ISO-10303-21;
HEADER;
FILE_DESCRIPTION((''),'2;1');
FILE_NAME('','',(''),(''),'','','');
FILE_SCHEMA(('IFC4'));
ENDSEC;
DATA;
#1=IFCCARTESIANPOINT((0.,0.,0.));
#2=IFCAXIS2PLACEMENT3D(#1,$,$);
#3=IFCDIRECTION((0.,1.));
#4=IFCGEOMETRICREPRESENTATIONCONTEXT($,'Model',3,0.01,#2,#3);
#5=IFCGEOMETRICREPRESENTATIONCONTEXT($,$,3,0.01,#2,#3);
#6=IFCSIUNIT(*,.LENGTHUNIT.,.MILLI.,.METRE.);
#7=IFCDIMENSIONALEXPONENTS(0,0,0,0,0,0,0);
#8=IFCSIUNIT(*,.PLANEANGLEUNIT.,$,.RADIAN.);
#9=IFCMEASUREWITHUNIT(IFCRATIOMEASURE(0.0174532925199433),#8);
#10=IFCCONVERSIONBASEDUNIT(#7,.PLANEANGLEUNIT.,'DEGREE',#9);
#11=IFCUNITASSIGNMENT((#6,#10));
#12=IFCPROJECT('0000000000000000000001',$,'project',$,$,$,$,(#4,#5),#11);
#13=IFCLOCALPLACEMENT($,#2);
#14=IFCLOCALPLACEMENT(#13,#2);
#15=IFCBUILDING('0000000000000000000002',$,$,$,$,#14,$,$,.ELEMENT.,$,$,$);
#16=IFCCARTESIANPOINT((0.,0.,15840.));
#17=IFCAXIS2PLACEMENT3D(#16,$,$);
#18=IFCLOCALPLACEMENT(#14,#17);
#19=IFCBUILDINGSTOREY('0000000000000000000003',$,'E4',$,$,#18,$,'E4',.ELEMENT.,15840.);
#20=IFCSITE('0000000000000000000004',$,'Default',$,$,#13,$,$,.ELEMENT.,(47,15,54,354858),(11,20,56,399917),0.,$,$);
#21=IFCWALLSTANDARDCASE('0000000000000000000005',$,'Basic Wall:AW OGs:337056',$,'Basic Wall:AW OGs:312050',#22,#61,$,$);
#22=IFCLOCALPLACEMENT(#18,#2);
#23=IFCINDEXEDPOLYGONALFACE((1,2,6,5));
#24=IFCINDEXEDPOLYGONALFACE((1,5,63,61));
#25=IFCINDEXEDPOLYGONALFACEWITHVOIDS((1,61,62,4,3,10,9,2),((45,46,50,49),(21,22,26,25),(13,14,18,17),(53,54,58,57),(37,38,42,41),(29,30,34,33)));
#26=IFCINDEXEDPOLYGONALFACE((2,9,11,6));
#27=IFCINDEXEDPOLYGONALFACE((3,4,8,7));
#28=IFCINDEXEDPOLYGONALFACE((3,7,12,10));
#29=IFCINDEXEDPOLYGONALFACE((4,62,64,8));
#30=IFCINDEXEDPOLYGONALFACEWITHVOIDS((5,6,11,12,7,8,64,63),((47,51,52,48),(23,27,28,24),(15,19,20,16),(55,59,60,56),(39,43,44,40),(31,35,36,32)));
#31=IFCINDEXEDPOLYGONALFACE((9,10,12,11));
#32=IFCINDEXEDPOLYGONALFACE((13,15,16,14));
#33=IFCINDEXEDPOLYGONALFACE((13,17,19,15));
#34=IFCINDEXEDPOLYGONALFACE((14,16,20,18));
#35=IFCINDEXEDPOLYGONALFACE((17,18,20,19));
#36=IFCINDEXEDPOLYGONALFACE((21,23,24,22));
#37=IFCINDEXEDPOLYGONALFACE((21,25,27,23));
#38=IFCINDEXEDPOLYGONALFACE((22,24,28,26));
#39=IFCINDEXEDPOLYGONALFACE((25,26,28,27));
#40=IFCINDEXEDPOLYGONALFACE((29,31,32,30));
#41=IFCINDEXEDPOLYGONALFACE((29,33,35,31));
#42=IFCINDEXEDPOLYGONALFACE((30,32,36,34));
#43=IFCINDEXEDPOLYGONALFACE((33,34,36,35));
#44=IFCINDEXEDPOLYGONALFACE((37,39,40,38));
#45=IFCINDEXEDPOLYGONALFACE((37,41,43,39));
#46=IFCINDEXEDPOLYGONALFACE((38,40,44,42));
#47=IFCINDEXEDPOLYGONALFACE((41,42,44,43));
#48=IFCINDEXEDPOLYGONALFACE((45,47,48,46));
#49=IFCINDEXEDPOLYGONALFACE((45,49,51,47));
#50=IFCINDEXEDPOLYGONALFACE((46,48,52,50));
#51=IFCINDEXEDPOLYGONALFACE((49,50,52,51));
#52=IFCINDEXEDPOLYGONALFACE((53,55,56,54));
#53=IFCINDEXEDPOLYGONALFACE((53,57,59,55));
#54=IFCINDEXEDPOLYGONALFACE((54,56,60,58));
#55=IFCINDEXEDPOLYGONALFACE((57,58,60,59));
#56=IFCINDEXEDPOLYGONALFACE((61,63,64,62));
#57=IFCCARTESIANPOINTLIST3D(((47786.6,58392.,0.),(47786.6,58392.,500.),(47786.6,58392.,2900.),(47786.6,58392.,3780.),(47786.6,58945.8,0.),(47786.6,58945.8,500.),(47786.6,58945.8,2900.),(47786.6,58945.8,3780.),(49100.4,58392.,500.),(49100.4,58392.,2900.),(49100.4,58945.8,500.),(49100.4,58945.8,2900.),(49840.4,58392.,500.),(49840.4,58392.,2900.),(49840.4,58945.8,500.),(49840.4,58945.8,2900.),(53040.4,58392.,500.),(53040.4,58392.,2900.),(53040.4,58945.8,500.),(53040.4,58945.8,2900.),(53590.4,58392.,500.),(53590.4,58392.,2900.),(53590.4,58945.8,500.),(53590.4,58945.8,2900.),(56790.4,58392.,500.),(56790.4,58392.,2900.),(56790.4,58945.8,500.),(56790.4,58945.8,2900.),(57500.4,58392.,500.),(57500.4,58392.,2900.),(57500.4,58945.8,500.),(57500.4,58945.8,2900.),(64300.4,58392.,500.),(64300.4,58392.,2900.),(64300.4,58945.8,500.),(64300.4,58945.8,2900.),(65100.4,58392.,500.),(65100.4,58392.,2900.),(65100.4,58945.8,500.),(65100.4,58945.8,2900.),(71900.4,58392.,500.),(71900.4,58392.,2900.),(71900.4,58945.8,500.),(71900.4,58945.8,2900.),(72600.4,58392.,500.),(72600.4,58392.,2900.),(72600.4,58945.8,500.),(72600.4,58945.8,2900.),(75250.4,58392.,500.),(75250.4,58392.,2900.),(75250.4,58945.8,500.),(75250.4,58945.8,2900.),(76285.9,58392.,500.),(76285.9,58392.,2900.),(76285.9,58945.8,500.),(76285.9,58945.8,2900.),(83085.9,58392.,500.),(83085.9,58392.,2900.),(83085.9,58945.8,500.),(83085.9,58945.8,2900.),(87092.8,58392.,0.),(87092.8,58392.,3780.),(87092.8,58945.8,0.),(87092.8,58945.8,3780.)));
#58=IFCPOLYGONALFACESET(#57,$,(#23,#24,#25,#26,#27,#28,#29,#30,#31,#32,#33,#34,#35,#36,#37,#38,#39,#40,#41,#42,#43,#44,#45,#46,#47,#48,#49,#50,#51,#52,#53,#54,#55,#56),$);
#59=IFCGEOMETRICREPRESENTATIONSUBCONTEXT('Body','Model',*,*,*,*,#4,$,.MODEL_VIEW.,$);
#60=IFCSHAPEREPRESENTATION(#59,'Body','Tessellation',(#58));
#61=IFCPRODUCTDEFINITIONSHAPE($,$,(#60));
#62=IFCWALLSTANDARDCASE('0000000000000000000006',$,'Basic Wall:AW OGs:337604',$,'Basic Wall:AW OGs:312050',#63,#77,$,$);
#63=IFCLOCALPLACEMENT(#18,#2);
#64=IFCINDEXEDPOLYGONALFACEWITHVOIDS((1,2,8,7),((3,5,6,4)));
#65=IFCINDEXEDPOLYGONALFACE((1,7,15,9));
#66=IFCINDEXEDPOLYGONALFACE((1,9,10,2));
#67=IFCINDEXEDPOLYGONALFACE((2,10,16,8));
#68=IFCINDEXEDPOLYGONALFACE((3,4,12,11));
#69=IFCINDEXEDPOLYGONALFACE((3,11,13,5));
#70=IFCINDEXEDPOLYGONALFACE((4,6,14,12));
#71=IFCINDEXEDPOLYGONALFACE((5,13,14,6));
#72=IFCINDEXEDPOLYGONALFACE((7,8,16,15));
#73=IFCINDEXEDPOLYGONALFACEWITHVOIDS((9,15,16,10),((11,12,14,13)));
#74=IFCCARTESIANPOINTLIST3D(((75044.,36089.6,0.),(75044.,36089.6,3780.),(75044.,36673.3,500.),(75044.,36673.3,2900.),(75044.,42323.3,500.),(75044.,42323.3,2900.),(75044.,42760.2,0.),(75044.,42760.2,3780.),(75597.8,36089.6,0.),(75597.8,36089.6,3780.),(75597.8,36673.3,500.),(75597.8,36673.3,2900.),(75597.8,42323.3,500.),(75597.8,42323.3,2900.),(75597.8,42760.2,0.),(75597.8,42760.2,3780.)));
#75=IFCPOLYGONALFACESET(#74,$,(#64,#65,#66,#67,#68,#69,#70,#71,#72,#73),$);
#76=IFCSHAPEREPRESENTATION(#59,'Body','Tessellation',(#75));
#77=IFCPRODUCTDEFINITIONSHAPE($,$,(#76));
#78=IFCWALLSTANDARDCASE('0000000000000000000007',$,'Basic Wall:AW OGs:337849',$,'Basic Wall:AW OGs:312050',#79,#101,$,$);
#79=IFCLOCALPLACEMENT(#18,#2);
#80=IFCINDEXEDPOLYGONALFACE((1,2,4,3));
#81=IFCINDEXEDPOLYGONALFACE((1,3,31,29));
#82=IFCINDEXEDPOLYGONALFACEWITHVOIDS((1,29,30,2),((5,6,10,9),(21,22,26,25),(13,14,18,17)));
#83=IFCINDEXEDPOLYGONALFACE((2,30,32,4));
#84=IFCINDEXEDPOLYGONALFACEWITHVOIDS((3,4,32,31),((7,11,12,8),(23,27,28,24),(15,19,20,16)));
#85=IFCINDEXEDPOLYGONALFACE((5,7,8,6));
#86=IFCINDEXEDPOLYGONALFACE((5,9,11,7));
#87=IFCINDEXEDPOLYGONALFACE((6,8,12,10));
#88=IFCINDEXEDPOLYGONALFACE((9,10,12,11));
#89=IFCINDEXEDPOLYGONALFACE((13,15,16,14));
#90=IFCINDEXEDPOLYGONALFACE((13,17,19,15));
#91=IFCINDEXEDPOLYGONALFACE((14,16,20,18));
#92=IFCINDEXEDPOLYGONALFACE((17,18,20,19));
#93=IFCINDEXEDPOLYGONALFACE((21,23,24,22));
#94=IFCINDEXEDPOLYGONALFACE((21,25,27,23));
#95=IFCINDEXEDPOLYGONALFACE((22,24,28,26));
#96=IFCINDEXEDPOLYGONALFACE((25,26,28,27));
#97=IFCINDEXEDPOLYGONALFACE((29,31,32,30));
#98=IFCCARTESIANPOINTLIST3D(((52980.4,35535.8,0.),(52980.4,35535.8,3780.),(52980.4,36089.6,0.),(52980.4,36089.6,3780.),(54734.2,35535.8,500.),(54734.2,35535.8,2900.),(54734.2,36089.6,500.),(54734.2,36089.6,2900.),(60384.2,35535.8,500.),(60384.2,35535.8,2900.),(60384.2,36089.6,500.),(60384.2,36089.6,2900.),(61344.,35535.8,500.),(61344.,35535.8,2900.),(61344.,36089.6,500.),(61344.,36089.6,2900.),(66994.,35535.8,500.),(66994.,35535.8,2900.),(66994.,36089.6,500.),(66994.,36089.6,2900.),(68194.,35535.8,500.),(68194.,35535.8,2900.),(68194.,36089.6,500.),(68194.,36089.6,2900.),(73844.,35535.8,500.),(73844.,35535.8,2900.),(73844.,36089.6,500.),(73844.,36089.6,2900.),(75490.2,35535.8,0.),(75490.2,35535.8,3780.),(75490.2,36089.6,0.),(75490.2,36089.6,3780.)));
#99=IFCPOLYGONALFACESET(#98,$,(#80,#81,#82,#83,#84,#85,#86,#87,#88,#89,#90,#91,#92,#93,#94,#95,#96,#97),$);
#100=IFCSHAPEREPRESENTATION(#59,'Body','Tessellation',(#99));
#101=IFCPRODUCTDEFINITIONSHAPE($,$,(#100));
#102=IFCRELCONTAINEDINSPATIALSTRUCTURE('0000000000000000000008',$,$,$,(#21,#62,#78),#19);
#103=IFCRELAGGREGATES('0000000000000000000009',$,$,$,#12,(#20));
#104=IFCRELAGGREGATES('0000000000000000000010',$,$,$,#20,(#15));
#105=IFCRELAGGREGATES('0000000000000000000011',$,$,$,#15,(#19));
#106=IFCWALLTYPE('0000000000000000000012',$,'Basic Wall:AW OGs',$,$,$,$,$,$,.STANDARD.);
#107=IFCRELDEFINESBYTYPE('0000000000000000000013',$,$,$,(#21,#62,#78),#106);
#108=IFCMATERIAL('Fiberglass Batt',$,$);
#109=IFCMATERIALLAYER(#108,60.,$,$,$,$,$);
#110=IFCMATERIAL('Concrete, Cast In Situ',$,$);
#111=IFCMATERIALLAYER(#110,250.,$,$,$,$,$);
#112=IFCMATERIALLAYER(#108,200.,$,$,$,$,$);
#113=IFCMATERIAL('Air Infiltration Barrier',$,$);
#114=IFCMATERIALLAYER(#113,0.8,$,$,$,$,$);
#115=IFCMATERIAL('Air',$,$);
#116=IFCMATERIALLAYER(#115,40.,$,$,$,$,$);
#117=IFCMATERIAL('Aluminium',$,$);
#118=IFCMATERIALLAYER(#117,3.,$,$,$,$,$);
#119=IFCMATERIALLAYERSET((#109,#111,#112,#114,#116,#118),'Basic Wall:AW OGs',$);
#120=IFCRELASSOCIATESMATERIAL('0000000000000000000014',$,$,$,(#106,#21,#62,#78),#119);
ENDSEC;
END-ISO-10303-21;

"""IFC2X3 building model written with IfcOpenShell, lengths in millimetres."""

from ifc_helpers import new_model, entity, si_unit, converted_unit, direction, frame, frame_2d, origin, place, context, subcontext, project, spatial, rectangle, extrude, material, layer, layer_set, layer_usage, type_object, element, save


model = new_model("IFC2X3")

# Units and contexts
model_context = context("Model", 3, precision=0.01, world=origin(), true_north=direction((0.0, 1.0)))
context_of_model = context(None, 3, precision=0.01, world=origin(), true_north=direction((0.0, 1.0)))
body_context = subcontext(model_context, "Body", "Model", "MODEL_VIEW")
ifc_project = project(units=[si_unit("LENGTHUNIT", "METRE", prefix="MILLI"), converted_unit("PLANEANGLEUNIT", "DEGREE", entity("IfcRatioMeasure", 0.0174532925199433), si_unit("PLANEANGLEUNIT", "RADIAN"), dimensions=[0, 0, 0, 0, 0, 0, 0])], contexts=[model_context, context_of_model])

# Site, building, storey
site_placement = place(None, origin())
site = spatial("IfcSite", under=ifc_project, at=site_placement, Name="Default", CompositionType="ELEMENT", RefLatitude=(47, 15, 54, 354858), RefLongitude=(11, 20, 56, 399917), RefElevation=0.0)
building_placement = place(site_placement, origin())
building = spatial("IfcBuilding", under=site, at=building_placement, CompositionType="ELEMENT")
storey_placement = place(building_placement, frame((0.0, 0.0, 15840.0)))
storey = spatial("IfcBuildingStorey", under=building, at=storey_placement, Name="E4", LongName="E4", CompositionType="ELEMENT", Elevation=15840.0)

# Shared definitions
ifc_material_1 = material(Name="Concrete, Cast In Situ")

# Shared definitions
ifc_material_2 = material(Name="Fiberglass Batt")
ifc_layer_1 = layer(ifc_material_2, 60.0)
ifc_layer_2 = layer(ifc_material_1, 250.0)
ifc_layer_3 = layer(ifc_material_2, 200.0)
ifc_material_3 = material(Name="Air Infiltration Barrier")
ifc_layer_4 = layer(ifc_material_3, 0.8)
ifc_material_4 = material(Name="Air")
ifc_layer_5 = layer(ifc_material_4, 40.0)
ifc_material_5 = material(Name="Aluminium")
ifc_layer_6 = layer(ifc_material_5, 3.0)
ifc_layer_set_1 = layer_set([ifc_layer_1, ifc_layer_2, ifc_layer_3, ifc_layer_4, ifc_layer_5, ifc_layer_6], Name="Basic Wall:AW OGs")
wall_type_1 = type_object("IfcWallType", Name="Basic Wall:AW OGs", PredefinedType="STANDARD", material=ifc_layer_set_1)

# Wall, openings
ifc_layer_usage_1 = layer_usage(ifc_layer_set_1, "AXIS2", "NEGATIVE", 276.9)
wall_1_placement = place(storey_placement, frame((87092.8, 58668.9, 0.0), z_axis=(0.0, 0.0, 1.0), x_axis=(-1.0, 0.0, 0.0)))
wall_1 = element("IfcWallStandardCase", 1, at=wall_1_placement, inside=storey, type_object=wall_type_1, material=ifc_layer_usage_1, Name="Basic Wall:AW OGs:337056", ObjectType="Basic Wall:AW OGs:312050", context=body_context, shape_type="SweptSolid", body=[
    extrude(rectangle(XDim=39306.2, YDim=553.8, at=frame_2d((19653.1, 0.0), x_axis=(-1.0, 0.0))), origin(), (0.0, 0.0, 1.0), 3780.0),
])
opening_1_placement = place(wall_1_placement, frame((44792.4, 276.9, 500.0)))
element("IfcOpeningElement", 2, at=opening_1_placement, cuts=wall_1, ObjectType="Opening", context=body_context, shape_type="SweptSolid", body=[
    extrude(rectangle(XDim=2400.0, YDim=6800.0, at=frame_2d((1200.0, 3400.0), x_axis=(-1.0, 0.0))), frame((0.0, 0.0, 0.0), z_axis=(0.0, -1.0, 0.0), x_axis=(0.0, 0.0, 1.0)), (0.0, 0.0, 1.0), 553.8),
])
opening_2_placement = place(wall_1_placement, frame((37252.4, 276.9, 500.0)))
element("IfcOpeningElement", 3, at=opening_2_placement, cuts=wall_1, ObjectType="Opening", context=body_context, shape_type="SweptSolid", body=[
    extrude(rectangle(XDim=2400.0, YDim=3200.0, at=frame_2d((1200.0, 1600.0), x_axis=(-1.0, 0.0))), frame((0.0, 0.0, 0.0), z_axis=(0.0, -1.0, 0.0), x_axis=(0.0, 0.0, 1.0)), (0.0, 0.0, 1.0), 553.8),
])
opening_3_placement = place(wall_1_placement, frame((10806.8, 276.9, 500.0)))
element("IfcOpeningElement", 4, at=opening_3_placement, cuts=wall_1, ObjectType="Opening", context=body_context, shape_type="SweptSolid", body=[
    extrude(rectangle(XDim=2400.0, YDim=6800.0, at=frame_2d((1200.0, 3400.0), x_axis=(-1.0, 0.0))), frame((0.0, 0.0, 0.0), z_axis=(0.0, -1.0, 0.0), x_axis=(0.0, 0.0, 1.0)), (0.0, 0.0, 1.0), 553.8),
])
opening_4_placement = place(wall_1_placement, frame((33502.4, 276.9, 500.0)))
element("IfcOpeningElement", 5, at=opening_4_placement, cuts=wall_1, ObjectType="Opening", context=body_context, shape_type="SweptSolid", body=[
    extrude(rectangle(XDim=2400.0, YDim=3200.0, at=frame_2d((1200.0, 1600.0), x_axis=(-1.0, 0.0))), frame((0.0, 0.0, 0.0), z_axis=(0.0, -1.0, 0.0), x_axis=(0.0, 0.0, 1.0)), (0.0, 0.0, 1.0), 553.8),
])
opening_5_placement = place(wall_1_placement, frame((14492.4, 276.9, 500.0)))
element("IfcOpeningElement", 6, at=opening_5_placement, cuts=wall_1, ObjectType="Opening", context=body_context, shape_type="SweptSolid", body=[
    extrude(rectangle(XDim=2400.0, YDim=2650.0, at=frame_2d((1200.0, 1325.0), x_axis=(-1.0, 0.0))), frame((0.0, 0.0, 0.0), z_axis=(0.0, -1.0, 0.0), x_axis=(0.0, 0.0, 1.0)), (0.0, 0.0, 1.0), 553.8),
])
opening_6_placement = place(wall_1_placement, frame((21992.4, 276.9, 500.0)))
element("IfcOpeningElement", 7, at=opening_6_placement, cuts=wall_1, ObjectType="Opening", context=body_context, shape_type="SweptSolid", body=[
    extrude(rectangle(XDim=2400.0, YDim=6800.0, at=frame_2d((1200.0, 3400.0), x_axis=(-1.0, 0.0))), frame((0.0, 0.0, 0.0), z_axis=(0.0, -1.0, 0.0), x_axis=(0.0, 0.0, 1.0)), (0.0, 0.0, 1.0), 553.8),
])
opening_7_placement = place(wall_1_placement, frame((29592.4, 276.9, 500.0)))
element("IfcOpeningElement", 8, at=opening_7_placement, cuts=wall_1, ObjectType="Opening", context=body_context, shape_type="SweptSolid", body=[
    extrude(rectangle(XDim=2400.0, YDim=6800.0, at=frame_2d((1200.0, 3400.0), x_axis=(-1.0, 0.0))), frame((0.0, 0.0, 0.0), z_axis=(0.0, -1.0, 0.0), x_axis=(0.0, 0.0, 1.0)), (0.0, 0.0, 1.0), 553.8),
])

# Wall, opening
ifc_layer_usage_2 = layer_usage(ifc_layer_set_1, "AXIS2", "NEGATIVE", 276.9)
wall_2_placement = place(storey_placement, frame((75320.9, 42760.2, 0.0), z_axis=(0.0, 0.0, 1.0), x_axis=(0.0, -1.0, 0.0)))
wall_2 = element("IfcWallStandardCase", 9, at=wall_2_placement, inside=storey, type_object=wall_type_1, material=ifc_layer_usage_2, Name="Basic Wall:AW OGs:337604", ObjectType="Basic Wall:AW OGs:312050", context=body_context, shape_type="SweptSolid", body=[
    extrude(rectangle(XDim=6670.6, YDim=553.8, at=frame_2d((3335.3, 0.0), x_axis=(-1.0, 0.0))), origin(), (0.0, 0.0, 1.0), 3780.0),
])
opening_8_placement = place(wall_2_placement, frame((6086.9, 276.9, 500.0)))
element("IfcOpeningElement", 10, at=opening_8_placement, cuts=wall_2, ObjectType="Opening", context=body_context, shape_type="SweptSolid", body=[
    extrude(rectangle(XDim=2400.0, YDim=5650.0, at=frame_2d((1200.0, 2825.0), x_axis=(-1.0, 0.0))), frame((0.0, 0.0, 0.0), z_axis=(0.0, -1.0, 0.0), x_axis=(0.0, 0.0, 1.0)), (0.0, 0.0, 1.0), 553.8),
])

# Wall, openings
ifc_layer_usage_3 = layer_usage(ifc_layer_set_1, "AXIS2", "NEGATIVE", 276.9)
wall_3_placement = place(storey_placement, frame((75597.8, 35812.7, 0.0), z_axis=(0.0, 0.0, 1.0), x_axis=(-1.0, 0.0, 0.0)))
wall_3 = element("IfcWallStandardCase", 11, at=wall_3_placement, inside=storey, type_object=wall_type_1, material=ifc_layer_usage_3, Name="Basic Wall:AW OGs:337849", ObjectType="Basic Wall:AW OGs:312050", context=body_context, shape_type="SweptSolid", body=[
    extrude(rectangle(XDim=22509.8, YDim=553.8, at=frame_2d((11362.5, 0.0), x_axis=(-1.0, 0.0))), origin(), (0.0, 0.0, 1.0), 3780.0),
])
opening_9_placement = place(wall_3_placement, frame((20863.6, 276.9, 500.0)))
element("IfcOpeningElement", 12, at=opening_9_placement, cuts=wall_3, ObjectType="Opening", context=body_context, shape_type="SweptSolid", body=[
    extrude(rectangle(XDim=2400.0, YDim=5650.0, at=frame_2d((1200.0, 2825.0), x_axis=(-1.0, 0.0))), frame((0.0, 0.0, 0.0), z_axis=(0.0, -1.0, 0.0), x_axis=(0.0, 0.0, 1.0)), (0.0, 0.0, 1.0), 553.8),
])
opening_10_placement = place(wall_3_placement, frame((14253.8, 276.9, 500.0)))
element("IfcOpeningElement", 13, at=opening_10_placement, cuts=wall_3, ObjectType="Opening", context=body_context, shape_type="SweptSolid", body=[
    extrude(rectangle(XDim=2400.0, YDim=5650.0, at=frame_2d((1200.0, 2825.0), x_axis=(-1.0, 0.0))), frame((0.0, 0.0, 0.0), z_axis=(0.0, -1.0, 0.0), x_axis=(0.0, 0.0, 1.0)), (0.0, 0.0, 1.0), 553.8),
])
opening_11_placement = place(wall_3_placement, frame((7403.8, 276.9, 500.0)))
element("IfcOpeningElement", 14, at=opening_11_placement, cuts=wall_3, ObjectType="Opening", context=body_context, shape_type="SweptSolid", body=[
    extrude(rectangle(XDim=2400.0, YDim=5650.0, at=frame_2d((1200.0, 2825.0), x_axis=(-1.0, 0.0))), frame((0.0, 0.0, 0.0), z_axis=(0.0, -1.0, 0.0), x_axis=(0.0, 0.0, 1.0)), (0.0, 0.0, 1.0), 553.8),
])

save(model, "model.ifc")
